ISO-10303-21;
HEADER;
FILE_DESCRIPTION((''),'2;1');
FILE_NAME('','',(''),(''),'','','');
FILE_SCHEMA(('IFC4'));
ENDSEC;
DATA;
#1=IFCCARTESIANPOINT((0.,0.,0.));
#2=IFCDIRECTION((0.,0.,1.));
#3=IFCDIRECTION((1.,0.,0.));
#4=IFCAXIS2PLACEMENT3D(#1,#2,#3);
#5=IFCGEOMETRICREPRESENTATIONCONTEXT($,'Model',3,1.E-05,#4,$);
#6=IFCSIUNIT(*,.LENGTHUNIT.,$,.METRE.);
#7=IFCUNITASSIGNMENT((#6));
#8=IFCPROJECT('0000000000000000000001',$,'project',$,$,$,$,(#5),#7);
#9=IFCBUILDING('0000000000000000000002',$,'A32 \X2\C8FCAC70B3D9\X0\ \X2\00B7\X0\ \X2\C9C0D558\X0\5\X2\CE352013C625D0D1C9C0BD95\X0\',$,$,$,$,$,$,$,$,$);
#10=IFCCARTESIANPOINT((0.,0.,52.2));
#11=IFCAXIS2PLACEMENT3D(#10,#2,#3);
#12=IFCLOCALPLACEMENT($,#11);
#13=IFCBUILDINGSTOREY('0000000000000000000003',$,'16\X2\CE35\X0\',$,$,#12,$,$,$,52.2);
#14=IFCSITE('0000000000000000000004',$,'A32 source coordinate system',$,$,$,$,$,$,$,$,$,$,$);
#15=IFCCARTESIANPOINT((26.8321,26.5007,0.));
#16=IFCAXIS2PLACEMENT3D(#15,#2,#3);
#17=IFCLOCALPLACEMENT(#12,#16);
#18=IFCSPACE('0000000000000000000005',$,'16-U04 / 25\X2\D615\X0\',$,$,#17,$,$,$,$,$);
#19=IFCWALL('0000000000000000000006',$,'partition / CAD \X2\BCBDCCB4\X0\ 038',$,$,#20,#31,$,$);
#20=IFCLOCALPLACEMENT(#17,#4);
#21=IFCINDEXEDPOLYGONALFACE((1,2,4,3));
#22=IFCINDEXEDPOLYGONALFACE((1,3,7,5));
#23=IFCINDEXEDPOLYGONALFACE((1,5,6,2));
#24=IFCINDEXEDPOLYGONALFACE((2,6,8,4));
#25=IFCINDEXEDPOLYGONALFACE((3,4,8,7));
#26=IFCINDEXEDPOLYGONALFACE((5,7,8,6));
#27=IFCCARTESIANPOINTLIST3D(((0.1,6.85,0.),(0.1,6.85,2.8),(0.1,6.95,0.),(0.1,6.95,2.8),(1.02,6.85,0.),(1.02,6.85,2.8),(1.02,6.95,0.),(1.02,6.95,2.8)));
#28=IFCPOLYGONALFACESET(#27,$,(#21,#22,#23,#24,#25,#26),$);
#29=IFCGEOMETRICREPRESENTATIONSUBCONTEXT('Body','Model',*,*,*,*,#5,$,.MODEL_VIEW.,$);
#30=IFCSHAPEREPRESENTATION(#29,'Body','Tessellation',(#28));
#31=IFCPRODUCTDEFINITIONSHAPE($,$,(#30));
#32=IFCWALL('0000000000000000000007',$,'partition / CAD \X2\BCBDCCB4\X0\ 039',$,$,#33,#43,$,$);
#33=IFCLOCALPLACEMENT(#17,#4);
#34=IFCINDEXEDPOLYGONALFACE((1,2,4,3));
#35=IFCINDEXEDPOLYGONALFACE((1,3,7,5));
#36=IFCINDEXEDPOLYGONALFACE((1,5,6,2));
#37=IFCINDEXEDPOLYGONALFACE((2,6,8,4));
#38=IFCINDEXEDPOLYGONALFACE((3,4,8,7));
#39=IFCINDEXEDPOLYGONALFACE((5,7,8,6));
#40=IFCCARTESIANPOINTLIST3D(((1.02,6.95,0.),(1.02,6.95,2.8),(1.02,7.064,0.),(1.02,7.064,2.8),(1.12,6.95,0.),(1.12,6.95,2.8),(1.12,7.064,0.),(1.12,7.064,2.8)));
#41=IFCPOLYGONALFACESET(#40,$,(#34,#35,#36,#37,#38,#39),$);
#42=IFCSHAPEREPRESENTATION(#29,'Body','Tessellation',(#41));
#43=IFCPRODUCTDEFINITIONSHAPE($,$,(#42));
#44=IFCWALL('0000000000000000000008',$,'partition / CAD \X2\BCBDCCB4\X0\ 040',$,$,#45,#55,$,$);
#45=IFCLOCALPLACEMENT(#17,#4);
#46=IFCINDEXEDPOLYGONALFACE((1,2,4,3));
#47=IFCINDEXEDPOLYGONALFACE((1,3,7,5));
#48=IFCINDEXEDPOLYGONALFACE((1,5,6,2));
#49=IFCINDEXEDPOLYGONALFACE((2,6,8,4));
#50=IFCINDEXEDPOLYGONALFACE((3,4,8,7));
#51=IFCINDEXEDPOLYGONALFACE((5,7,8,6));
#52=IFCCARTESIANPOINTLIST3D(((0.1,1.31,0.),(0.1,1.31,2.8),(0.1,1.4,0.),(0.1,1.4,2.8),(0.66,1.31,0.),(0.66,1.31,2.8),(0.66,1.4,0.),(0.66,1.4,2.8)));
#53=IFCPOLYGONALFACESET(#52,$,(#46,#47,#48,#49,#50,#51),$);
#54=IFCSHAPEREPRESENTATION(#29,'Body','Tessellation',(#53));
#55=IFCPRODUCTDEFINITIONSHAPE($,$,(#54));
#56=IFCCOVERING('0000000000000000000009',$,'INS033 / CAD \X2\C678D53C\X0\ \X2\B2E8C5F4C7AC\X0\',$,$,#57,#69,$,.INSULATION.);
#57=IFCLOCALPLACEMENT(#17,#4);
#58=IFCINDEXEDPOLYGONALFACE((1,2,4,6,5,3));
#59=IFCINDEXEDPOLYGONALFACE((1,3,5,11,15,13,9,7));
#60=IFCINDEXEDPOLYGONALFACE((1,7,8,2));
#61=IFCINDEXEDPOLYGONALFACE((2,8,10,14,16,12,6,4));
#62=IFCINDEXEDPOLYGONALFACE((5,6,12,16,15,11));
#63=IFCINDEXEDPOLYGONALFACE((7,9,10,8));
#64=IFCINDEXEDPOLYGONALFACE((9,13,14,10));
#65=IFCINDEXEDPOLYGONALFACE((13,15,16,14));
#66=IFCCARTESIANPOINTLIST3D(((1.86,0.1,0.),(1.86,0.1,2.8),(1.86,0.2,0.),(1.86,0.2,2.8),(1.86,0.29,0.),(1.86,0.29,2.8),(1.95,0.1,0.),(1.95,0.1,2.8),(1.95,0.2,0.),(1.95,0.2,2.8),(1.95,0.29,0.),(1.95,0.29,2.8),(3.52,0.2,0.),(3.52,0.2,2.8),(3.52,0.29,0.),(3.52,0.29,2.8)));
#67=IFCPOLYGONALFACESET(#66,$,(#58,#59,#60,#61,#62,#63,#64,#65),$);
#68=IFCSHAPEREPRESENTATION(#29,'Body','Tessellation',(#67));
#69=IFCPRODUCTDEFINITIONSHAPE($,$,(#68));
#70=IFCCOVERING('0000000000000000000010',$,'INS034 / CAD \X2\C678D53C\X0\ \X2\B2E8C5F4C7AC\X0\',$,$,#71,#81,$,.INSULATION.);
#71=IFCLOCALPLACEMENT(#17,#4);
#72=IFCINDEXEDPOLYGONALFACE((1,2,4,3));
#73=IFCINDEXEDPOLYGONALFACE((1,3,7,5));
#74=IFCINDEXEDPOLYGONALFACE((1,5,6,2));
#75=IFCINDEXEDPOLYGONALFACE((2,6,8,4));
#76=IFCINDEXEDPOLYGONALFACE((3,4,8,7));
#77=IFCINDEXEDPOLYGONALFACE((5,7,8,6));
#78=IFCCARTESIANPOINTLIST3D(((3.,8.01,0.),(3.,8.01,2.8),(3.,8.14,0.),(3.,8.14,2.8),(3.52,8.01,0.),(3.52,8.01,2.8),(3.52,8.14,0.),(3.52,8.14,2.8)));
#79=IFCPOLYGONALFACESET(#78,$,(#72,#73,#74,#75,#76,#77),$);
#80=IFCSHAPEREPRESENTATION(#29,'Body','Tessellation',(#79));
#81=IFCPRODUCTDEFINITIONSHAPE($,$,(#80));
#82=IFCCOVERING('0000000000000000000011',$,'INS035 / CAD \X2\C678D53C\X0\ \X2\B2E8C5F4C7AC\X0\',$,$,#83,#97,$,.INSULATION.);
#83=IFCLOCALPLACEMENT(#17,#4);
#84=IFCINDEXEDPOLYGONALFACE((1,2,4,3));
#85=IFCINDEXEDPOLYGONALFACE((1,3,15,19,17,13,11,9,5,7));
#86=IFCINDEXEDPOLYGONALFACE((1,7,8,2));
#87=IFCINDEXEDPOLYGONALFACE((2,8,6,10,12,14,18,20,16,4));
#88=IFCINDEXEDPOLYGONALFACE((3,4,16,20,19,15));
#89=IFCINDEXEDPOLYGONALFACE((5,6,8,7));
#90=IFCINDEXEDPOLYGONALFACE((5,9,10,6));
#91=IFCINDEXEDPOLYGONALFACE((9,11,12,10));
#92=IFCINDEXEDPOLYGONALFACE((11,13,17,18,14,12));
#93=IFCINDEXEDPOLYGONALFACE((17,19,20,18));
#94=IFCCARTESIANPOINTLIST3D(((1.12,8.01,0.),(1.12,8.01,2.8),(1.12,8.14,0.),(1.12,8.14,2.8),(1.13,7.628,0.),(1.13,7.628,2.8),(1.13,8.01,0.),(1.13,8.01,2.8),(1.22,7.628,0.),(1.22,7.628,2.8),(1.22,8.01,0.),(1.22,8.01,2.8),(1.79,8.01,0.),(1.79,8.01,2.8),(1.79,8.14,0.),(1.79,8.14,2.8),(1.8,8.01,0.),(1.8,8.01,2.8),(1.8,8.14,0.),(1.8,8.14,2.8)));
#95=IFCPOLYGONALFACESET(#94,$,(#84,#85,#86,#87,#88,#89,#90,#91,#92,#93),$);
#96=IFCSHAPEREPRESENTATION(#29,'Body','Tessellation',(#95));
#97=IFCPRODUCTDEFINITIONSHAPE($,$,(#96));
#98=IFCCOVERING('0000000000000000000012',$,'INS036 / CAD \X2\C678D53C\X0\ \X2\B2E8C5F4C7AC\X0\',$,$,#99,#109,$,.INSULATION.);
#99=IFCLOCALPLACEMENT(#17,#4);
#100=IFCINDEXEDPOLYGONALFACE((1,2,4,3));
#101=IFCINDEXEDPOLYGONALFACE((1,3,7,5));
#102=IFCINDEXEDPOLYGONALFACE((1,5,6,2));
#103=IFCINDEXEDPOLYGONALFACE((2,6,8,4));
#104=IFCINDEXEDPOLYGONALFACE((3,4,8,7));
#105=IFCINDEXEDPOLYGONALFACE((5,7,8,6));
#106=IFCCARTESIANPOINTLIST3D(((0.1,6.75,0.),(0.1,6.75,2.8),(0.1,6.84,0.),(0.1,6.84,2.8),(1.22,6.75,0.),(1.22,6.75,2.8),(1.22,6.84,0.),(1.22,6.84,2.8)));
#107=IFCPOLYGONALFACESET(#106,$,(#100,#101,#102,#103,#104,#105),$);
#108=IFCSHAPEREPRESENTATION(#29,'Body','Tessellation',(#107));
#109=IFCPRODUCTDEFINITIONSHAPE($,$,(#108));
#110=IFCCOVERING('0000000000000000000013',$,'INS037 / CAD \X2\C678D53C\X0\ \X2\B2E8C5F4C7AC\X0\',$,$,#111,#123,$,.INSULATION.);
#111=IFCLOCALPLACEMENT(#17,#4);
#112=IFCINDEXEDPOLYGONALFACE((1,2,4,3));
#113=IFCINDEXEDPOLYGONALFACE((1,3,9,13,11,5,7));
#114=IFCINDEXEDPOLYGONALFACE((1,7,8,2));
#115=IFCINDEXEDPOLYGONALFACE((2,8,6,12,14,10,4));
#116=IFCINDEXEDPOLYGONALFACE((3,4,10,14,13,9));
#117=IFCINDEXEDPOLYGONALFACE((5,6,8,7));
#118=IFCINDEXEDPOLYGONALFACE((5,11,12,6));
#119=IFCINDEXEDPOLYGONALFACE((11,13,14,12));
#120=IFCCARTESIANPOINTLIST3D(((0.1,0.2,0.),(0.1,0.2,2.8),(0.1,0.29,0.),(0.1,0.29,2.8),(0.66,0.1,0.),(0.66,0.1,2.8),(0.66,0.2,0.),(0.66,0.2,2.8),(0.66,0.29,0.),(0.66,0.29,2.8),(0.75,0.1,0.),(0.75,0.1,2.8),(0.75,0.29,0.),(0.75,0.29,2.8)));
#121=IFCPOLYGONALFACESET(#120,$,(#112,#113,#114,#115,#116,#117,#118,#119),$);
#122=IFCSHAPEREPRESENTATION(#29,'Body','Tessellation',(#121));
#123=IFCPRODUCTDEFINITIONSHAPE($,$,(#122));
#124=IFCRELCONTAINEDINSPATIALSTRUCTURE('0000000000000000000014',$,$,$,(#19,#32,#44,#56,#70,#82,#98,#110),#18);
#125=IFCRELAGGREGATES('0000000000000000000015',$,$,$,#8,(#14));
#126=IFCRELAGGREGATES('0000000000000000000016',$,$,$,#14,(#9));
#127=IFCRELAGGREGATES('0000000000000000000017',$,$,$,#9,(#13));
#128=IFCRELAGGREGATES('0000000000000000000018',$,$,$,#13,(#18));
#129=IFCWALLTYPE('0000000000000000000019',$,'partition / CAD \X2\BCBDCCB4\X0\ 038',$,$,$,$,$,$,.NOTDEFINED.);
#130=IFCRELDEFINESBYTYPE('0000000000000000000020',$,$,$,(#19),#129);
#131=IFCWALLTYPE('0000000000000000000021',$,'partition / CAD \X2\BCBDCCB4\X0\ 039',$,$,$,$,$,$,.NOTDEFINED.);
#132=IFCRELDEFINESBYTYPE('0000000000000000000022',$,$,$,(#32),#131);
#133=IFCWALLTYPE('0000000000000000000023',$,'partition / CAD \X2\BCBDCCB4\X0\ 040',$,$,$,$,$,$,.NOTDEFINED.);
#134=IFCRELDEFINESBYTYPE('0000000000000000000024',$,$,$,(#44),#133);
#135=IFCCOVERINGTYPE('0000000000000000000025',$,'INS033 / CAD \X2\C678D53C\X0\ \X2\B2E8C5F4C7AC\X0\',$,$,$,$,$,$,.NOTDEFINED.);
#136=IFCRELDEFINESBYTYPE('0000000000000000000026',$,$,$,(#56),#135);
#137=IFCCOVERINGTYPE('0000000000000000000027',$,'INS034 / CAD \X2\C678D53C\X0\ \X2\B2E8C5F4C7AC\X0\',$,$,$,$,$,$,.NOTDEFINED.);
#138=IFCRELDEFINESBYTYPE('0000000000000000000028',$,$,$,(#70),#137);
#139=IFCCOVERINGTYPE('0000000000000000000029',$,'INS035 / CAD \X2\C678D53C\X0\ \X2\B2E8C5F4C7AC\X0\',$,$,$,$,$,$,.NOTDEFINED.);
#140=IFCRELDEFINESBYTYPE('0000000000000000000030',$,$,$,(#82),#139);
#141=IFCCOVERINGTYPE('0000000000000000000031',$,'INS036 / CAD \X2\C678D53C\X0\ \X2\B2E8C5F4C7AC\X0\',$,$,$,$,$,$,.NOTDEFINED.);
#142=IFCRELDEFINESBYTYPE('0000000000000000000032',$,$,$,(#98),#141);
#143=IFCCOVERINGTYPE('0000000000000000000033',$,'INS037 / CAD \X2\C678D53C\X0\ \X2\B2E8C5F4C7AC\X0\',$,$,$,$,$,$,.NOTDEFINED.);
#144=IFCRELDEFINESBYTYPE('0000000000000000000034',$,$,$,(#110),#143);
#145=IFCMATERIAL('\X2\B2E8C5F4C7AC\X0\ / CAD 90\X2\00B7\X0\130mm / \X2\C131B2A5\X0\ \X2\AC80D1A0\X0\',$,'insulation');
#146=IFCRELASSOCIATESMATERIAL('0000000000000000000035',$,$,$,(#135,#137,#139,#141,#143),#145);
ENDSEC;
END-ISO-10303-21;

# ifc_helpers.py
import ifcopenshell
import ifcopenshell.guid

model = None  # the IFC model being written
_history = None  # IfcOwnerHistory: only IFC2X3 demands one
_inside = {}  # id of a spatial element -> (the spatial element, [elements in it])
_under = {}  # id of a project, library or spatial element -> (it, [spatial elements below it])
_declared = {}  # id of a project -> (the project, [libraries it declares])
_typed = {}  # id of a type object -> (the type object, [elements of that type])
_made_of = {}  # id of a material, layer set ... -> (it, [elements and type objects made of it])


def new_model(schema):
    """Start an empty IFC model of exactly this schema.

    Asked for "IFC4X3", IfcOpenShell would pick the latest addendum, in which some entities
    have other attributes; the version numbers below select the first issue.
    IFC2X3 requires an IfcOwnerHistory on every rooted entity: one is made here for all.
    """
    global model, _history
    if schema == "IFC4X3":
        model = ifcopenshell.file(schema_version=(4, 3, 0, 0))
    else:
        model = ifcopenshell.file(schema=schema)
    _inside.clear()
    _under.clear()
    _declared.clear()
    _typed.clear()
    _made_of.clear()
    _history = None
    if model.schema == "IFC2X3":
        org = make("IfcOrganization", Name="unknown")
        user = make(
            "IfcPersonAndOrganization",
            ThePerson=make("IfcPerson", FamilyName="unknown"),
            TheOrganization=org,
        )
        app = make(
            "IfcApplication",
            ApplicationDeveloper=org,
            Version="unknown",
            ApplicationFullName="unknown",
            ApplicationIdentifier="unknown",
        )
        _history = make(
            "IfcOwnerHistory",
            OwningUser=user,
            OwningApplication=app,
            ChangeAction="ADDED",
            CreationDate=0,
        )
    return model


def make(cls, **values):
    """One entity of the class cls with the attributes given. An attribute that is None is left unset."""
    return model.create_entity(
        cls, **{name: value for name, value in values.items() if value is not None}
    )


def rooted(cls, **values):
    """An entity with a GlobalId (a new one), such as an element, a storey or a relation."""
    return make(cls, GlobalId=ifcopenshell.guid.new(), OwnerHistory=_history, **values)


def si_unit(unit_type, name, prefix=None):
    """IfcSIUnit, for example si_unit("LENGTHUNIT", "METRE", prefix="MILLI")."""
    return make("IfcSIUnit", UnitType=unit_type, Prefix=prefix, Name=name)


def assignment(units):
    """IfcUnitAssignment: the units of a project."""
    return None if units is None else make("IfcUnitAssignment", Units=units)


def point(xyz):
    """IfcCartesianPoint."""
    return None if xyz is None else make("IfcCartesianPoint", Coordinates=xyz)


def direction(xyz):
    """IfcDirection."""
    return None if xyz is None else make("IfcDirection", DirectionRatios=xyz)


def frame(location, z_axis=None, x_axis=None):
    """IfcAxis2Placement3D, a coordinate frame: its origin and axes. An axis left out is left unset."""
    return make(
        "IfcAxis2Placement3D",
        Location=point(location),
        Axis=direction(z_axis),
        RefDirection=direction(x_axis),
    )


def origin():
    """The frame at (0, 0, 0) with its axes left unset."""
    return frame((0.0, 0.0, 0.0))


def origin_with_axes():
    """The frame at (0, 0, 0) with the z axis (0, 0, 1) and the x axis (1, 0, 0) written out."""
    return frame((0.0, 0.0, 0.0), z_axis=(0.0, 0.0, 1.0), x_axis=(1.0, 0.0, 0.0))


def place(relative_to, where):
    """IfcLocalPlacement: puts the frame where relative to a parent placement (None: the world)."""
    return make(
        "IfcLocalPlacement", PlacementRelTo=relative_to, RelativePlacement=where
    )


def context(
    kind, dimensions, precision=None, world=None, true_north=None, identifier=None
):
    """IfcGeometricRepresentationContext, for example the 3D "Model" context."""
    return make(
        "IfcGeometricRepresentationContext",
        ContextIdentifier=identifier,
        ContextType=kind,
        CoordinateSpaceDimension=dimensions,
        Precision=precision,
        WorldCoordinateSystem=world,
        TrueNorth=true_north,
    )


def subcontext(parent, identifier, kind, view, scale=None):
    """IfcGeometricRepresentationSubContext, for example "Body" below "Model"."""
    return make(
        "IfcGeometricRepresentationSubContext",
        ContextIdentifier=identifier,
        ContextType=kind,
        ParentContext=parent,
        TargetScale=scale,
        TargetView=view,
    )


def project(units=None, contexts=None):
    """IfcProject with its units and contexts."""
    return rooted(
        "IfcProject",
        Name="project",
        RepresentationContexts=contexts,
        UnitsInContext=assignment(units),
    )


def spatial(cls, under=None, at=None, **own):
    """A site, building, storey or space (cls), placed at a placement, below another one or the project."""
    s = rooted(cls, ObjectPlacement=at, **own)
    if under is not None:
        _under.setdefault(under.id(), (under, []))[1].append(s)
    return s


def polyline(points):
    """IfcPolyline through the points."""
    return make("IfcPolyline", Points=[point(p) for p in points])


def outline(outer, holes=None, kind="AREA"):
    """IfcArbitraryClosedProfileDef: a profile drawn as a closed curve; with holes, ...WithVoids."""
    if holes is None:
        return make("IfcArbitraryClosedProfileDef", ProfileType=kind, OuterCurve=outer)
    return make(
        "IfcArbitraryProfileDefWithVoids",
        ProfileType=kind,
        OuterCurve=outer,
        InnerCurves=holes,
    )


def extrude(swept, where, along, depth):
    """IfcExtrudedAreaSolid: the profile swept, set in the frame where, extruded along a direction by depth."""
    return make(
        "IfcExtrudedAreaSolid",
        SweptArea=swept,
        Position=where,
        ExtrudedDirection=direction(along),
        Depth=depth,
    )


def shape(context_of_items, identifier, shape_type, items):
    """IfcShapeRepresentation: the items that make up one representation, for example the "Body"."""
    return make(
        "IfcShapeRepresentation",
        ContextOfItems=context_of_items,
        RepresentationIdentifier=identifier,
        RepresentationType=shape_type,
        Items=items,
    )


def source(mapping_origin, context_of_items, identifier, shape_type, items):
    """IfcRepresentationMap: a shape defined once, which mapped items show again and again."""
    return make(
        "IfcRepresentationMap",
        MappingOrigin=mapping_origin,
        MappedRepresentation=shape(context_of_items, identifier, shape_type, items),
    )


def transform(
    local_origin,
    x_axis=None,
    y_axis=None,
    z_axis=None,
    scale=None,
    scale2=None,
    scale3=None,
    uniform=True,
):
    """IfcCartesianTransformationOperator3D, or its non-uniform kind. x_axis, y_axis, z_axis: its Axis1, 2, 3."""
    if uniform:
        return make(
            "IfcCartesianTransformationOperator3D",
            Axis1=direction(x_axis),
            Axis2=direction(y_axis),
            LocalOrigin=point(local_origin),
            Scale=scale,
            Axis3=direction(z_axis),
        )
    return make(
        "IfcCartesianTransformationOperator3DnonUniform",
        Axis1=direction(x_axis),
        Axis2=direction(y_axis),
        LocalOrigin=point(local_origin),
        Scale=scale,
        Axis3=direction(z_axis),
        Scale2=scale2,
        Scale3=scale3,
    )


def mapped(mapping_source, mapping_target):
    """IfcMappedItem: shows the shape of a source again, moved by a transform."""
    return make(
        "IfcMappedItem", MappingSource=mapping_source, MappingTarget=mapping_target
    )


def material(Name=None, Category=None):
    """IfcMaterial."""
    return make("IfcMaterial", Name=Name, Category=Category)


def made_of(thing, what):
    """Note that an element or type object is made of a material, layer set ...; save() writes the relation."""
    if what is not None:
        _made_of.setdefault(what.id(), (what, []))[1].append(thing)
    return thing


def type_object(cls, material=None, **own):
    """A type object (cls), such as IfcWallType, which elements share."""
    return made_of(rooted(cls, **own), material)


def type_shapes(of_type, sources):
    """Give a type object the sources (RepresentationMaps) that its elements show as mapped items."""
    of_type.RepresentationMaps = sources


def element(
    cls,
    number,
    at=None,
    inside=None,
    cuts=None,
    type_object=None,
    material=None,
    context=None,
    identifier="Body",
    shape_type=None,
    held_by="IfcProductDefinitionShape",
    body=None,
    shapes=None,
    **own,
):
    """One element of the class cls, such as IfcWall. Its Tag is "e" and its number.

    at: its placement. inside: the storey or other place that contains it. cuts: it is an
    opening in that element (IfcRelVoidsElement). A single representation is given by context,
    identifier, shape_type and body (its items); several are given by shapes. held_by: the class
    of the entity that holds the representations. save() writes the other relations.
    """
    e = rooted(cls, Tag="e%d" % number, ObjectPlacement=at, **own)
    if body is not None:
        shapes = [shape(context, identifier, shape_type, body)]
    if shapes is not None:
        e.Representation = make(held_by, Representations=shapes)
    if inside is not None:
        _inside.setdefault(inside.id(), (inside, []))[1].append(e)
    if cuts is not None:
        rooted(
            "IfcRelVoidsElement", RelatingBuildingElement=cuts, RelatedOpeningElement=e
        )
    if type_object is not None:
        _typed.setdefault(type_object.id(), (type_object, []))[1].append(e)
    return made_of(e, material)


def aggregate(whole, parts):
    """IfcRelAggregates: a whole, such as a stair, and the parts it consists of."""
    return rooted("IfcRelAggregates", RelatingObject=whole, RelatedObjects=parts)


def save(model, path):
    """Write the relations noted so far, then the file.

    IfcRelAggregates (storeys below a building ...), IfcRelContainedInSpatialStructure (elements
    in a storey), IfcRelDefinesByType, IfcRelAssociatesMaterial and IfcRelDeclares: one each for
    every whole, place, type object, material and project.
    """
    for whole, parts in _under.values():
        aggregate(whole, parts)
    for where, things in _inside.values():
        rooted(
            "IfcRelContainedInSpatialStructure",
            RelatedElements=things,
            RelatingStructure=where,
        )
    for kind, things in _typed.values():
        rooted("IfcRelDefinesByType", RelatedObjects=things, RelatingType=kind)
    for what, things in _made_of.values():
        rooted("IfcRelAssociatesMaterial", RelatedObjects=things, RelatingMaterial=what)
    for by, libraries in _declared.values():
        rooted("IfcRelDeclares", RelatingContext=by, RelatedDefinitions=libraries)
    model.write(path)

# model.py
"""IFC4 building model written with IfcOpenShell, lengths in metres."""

from ifc_helpers import new_model, si_unit, frame, origin, origin_with_axes, place, context, subcontext, project, spatial, polyline, outline, extrude, source, transform, mapped, material, type_object, type_shapes, element, save


model = new_model("IFC4")

# Units and contexts
model_context = context("Model", 3, precision=1e-05, world=origin_with_axes())
body_context = subcontext(model_context, "Body", "Model", "MODEL_VIEW")
ifc_project = project(units=[si_unit("LENGTHUNIT", "METRE")], contexts=[model_context])

# Site, building, storey, space
storey_placement = place(None, frame((0.0, 0.0, 52.2), z_axis=(0.0, 0.0, 1.0), x_axis=(1.0, 0.0, 0.0)))
space_placement = place(storey_placement, frame((26.8321, 26.5007, 0.0), z_axis=(0.0, 0.0, 1.0), x_axis=(1.0, 0.0, 0.0)))
site = spatial("IfcSite", under=ifc_project, Name="A32 source coordinate system")
building = spatial("IfcBuilding", under=site, Name="A32 주거동 · 지하5층–옥탑지붕")
storey = spatial("IfcBuildingStorey", under=building, at=storey_placement, Name="16층", Elevation=52.2)
space = spatial("IfcSpace", under=storey, at=space_placement, Name="16-U04 / 25형")

# Walls
wall_type_1 = type_object("IfcWallType", Name="partition / CAD 벽체 038", PredefinedType="NOTDEFINED")
shared_shape_1 = source(origin(), body_context, "Body", "SweptSolid", [
    extrude(outline(polyline([(0.1, 6.95), (1.02, 6.95), (1.02, 6.85), (0.1, 6.85), (0.1, 6.95)])), origin(), (0.0, 0.0, 1.0), 2.8),
])
type_shapes(wall_type_1, [shared_shape_1])
wall_1_placement = place(space_placement, origin_with_axes())
element("IfcWall", 1, at=wall_1_placement, inside=space, type_object=wall_type_1, Name="partition / CAD 벽체 038", context=body_context, shape_type="MappedRepresentation", body=[
    mapped(shared_shape_1, transform((0.0, 0.0, 0.0), scale=1.0)),
])
wall_type_2 = type_object("IfcWallType", Name="partition / CAD 벽체 039", PredefinedType="NOTDEFINED")
shared_shape_2 = source(origin(), body_context, "Body", "SweptSolid", [
    extrude(outline(polyline([(1.02, 6.95), (1.02, 7.064), (1.12, 7.064), (1.12, 6.95), (1.02, 6.95)])), origin(), (0.0, 0.0, 1.0), 2.8),
])
type_shapes(wall_type_2, [shared_shape_2])
wall_2_placement = place(space_placement, origin_with_axes())
element("IfcWall", 2, at=wall_2_placement, inside=space, type_object=wall_type_2, Name="partition / CAD 벽체 039", context=body_context, shape_type="MappedRepresentation", body=[
    mapped(shared_shape_2, transform((0.0, 0.0, 0.0), scale=1.0)),
])
wall_type_3 = type_object("IfcWallType", Name="partition / CAD 벽체 040", PredefinedType="NOTDEFINED")
shared_shape_3 = source(origin(), body_context, "Body", "SweptSolid", [
    extrude(outline(polyline([(0.1, 1.4), (0.66, 1.4), (0.66, 1.31), (0.1, 1.31), (0.1, 1.4)])), origin(), (0.0, 0.0, 1.0), 2.8),
])
type_shapes(wall_type_3, [shared_shape_3])
wall_3_placement = place(space_placement, origin_with_axes())
element("IfcWall", 3, at=wall_3_placement, inside=space, type_object=wall_type_3, Name="partition / CAD 벽체 040", context=body_context, shape_type="MappedRepresentation", body=[
    mapped(shared_shape_3, transform((0.0, 0.0, 0.0), scale=1.0)),
])

# Coverings
ifc_material = material(Name="단열재 / CAD 90·130mm / 성능 검토", Category="insulation")
covering_type_1 = type_object("IfcCoveringType", Name="INS033 / CAD 외피 단열재", PredefinedType="NOTDEFINED", material=ifc_material)
shared_shape_4 = source(origin(), body_context, "Body", "SweptSolid", [
    extrude(outline(polyline([(1.95, 0.29), (3.52, 0.29), (3.52, 0.2), (1.95, 0.2), (1.95, 0.1), (1.86, 0.1), (1.86, 0.2), (1.86, 0.29), (1.95, 0.29)])), origin(), (0.0, 0.0, 1.0), 2.8),
])
type_shapes(covering_type_1, [shared_shape_4])
covering_1_placement = place(space_placement, origin_with_axes())
element("IfcCovering", 4, at=covering_1_placement, inside=space, type_object=covering_type_1, Name="INS033 / CAD 외피 단열재", PredefinedType="INSULATION", context=body_context, shape_type="MappedRepresentation", body=[
    mapped(shared_shape_4, transform((0.0, 0.0, 0.0), scale=1.0)),
])
covering_type_2 = type_object("IfcCoveringType", Name="INS034 / CAD 외피 단열재", PredefinedType="NOTDEFINED", material=ifc_material)
shared_shape_5 = source(origin(), body_context, "Body", "SweptSolid", [
    extrude(outline(polyline([(3.52, 8.01), (3.0, 8.01), (3.0, 8.14), (3.52, 8.14), (3.52, 8.01)])), origin(), (0.0, 0.0, 1.0), 2.8),
])
type_shapes(covering_type_2, [shared_shape_5])
covering_2_placement = place(space_placement, origin_with_axes())
element("IfcCovering", 5, at=covering_2_placement, inside=space, type_object=covering_type_2, Name="INS034 / CAD 외피 단열재", PredefinedType="INSULATION", context=body_context, shape_type="MappedRepresentation", body=[
    mapped(shared_shape_5, transform((0.0, 0.0, 0.0), scale=1.0)),
])
covering_type_3 = type_object("IfcCoveringType", Name="INS035 / CAD 외피 단열재", PredefinedType="NOTDEFINED", material=ifc_material)
shared_shape_6 = source(origin(), body_context, "Body", "SweptSolid", [
    extrude(outline(polyline([(1.8, 8.01), (1.79, 8.01), (1.22, 8.01), (1.22, 7.628), (1.13, 7.628), (1.13, 8.01), (1.12, 8.01), (1.12, 8.14), (1.79, 8.14), (1.8, 8.14), (1.8, 8.01)])), origin(), (0.0, 0.0, 1.0), 2.8),
])
type_shapes(covering_type_3, [shared_shape_6])
covering_3_placement = place(space_placement, origin_with_axes())
element("IfcCovering", 6, at=covering_3_placement, inside=space, type_object=covering_type_3, Name="INS035 / CAD 외피 단열재", PredefinedType="INSULATION", context=body_context, shape_type="MappedRepresentation", body=[
    mapped(shared_shape_6, transform((0.0, 0.0, 0.0), scale=1.0)),
])
covering_type_4 = type_object("IfcCoveringType", Name="INS036 / CAD 외피 단열재", PredefinedType="NOTDEFINED", material=ifc_material)
shared_shape_7 = source(origin(), body_context, "Body", "SweptSolid", [
    extrude(outline(polyline([(1.22, 6.84), (1.22, 6.75), (0.1, 6.75), (0.1, 6.84), (1.22, 6.84)])), origin(), (0.0, 0.0, 1.0), 2.8),
])
type_shapes(covering_type_4, [shared_shape_7])
covering_4_placement = place(space_placement, origin_with_axes())
element("IfcCovering", 7, at=covering_4_placement, inside=space, type_object=covering_type_4, Name="INS036 / CAD 외피 단열재", PredefinedType="INSULATION", context=body_context, shape_type="MappedRepresentation", body=[
    mapped(shared_shape_7, transform((0.0, 0.0, 0.0), scale=1.0)),
])
covering_type_5 = type_object("IfcCoveringType", Name="INS037 / CAD 외피 단열재", PredefinedType="NOTDEFINED", material=ifc_material)
shared_shape_8 = source(origin(), body_context, "Body", "SweptSolid", [
    extrude(outline(polyline([(0.1, 0.2), (0.1, 0.29), (0.66, 0.29), (0.75, 0.29), (0.75, 0.1), (0.66, 0.1), (0.66, 0.2), (0.1, 0.2)])), origin(), (0.0, 0.0, 1.0), 2.8),
])
type_shapes(covering_type_5, [shared_shape_8])
covering_5_placement = place(space_placement, origin_with_axes())
element("IfcCovering", 8, at=covering_5_placement, inside=space, type_object=covering_type_5, Name="INS037 / CAD 외피 단열재", PredefinedType="INSULATION", context=body_context, shape_type="MappedRepresentation", body=[
    mapped(shared_shape_8, transform((0.0, 0.0, 0.0), scale=1.0)),
])

save(model, "model.ifc")
